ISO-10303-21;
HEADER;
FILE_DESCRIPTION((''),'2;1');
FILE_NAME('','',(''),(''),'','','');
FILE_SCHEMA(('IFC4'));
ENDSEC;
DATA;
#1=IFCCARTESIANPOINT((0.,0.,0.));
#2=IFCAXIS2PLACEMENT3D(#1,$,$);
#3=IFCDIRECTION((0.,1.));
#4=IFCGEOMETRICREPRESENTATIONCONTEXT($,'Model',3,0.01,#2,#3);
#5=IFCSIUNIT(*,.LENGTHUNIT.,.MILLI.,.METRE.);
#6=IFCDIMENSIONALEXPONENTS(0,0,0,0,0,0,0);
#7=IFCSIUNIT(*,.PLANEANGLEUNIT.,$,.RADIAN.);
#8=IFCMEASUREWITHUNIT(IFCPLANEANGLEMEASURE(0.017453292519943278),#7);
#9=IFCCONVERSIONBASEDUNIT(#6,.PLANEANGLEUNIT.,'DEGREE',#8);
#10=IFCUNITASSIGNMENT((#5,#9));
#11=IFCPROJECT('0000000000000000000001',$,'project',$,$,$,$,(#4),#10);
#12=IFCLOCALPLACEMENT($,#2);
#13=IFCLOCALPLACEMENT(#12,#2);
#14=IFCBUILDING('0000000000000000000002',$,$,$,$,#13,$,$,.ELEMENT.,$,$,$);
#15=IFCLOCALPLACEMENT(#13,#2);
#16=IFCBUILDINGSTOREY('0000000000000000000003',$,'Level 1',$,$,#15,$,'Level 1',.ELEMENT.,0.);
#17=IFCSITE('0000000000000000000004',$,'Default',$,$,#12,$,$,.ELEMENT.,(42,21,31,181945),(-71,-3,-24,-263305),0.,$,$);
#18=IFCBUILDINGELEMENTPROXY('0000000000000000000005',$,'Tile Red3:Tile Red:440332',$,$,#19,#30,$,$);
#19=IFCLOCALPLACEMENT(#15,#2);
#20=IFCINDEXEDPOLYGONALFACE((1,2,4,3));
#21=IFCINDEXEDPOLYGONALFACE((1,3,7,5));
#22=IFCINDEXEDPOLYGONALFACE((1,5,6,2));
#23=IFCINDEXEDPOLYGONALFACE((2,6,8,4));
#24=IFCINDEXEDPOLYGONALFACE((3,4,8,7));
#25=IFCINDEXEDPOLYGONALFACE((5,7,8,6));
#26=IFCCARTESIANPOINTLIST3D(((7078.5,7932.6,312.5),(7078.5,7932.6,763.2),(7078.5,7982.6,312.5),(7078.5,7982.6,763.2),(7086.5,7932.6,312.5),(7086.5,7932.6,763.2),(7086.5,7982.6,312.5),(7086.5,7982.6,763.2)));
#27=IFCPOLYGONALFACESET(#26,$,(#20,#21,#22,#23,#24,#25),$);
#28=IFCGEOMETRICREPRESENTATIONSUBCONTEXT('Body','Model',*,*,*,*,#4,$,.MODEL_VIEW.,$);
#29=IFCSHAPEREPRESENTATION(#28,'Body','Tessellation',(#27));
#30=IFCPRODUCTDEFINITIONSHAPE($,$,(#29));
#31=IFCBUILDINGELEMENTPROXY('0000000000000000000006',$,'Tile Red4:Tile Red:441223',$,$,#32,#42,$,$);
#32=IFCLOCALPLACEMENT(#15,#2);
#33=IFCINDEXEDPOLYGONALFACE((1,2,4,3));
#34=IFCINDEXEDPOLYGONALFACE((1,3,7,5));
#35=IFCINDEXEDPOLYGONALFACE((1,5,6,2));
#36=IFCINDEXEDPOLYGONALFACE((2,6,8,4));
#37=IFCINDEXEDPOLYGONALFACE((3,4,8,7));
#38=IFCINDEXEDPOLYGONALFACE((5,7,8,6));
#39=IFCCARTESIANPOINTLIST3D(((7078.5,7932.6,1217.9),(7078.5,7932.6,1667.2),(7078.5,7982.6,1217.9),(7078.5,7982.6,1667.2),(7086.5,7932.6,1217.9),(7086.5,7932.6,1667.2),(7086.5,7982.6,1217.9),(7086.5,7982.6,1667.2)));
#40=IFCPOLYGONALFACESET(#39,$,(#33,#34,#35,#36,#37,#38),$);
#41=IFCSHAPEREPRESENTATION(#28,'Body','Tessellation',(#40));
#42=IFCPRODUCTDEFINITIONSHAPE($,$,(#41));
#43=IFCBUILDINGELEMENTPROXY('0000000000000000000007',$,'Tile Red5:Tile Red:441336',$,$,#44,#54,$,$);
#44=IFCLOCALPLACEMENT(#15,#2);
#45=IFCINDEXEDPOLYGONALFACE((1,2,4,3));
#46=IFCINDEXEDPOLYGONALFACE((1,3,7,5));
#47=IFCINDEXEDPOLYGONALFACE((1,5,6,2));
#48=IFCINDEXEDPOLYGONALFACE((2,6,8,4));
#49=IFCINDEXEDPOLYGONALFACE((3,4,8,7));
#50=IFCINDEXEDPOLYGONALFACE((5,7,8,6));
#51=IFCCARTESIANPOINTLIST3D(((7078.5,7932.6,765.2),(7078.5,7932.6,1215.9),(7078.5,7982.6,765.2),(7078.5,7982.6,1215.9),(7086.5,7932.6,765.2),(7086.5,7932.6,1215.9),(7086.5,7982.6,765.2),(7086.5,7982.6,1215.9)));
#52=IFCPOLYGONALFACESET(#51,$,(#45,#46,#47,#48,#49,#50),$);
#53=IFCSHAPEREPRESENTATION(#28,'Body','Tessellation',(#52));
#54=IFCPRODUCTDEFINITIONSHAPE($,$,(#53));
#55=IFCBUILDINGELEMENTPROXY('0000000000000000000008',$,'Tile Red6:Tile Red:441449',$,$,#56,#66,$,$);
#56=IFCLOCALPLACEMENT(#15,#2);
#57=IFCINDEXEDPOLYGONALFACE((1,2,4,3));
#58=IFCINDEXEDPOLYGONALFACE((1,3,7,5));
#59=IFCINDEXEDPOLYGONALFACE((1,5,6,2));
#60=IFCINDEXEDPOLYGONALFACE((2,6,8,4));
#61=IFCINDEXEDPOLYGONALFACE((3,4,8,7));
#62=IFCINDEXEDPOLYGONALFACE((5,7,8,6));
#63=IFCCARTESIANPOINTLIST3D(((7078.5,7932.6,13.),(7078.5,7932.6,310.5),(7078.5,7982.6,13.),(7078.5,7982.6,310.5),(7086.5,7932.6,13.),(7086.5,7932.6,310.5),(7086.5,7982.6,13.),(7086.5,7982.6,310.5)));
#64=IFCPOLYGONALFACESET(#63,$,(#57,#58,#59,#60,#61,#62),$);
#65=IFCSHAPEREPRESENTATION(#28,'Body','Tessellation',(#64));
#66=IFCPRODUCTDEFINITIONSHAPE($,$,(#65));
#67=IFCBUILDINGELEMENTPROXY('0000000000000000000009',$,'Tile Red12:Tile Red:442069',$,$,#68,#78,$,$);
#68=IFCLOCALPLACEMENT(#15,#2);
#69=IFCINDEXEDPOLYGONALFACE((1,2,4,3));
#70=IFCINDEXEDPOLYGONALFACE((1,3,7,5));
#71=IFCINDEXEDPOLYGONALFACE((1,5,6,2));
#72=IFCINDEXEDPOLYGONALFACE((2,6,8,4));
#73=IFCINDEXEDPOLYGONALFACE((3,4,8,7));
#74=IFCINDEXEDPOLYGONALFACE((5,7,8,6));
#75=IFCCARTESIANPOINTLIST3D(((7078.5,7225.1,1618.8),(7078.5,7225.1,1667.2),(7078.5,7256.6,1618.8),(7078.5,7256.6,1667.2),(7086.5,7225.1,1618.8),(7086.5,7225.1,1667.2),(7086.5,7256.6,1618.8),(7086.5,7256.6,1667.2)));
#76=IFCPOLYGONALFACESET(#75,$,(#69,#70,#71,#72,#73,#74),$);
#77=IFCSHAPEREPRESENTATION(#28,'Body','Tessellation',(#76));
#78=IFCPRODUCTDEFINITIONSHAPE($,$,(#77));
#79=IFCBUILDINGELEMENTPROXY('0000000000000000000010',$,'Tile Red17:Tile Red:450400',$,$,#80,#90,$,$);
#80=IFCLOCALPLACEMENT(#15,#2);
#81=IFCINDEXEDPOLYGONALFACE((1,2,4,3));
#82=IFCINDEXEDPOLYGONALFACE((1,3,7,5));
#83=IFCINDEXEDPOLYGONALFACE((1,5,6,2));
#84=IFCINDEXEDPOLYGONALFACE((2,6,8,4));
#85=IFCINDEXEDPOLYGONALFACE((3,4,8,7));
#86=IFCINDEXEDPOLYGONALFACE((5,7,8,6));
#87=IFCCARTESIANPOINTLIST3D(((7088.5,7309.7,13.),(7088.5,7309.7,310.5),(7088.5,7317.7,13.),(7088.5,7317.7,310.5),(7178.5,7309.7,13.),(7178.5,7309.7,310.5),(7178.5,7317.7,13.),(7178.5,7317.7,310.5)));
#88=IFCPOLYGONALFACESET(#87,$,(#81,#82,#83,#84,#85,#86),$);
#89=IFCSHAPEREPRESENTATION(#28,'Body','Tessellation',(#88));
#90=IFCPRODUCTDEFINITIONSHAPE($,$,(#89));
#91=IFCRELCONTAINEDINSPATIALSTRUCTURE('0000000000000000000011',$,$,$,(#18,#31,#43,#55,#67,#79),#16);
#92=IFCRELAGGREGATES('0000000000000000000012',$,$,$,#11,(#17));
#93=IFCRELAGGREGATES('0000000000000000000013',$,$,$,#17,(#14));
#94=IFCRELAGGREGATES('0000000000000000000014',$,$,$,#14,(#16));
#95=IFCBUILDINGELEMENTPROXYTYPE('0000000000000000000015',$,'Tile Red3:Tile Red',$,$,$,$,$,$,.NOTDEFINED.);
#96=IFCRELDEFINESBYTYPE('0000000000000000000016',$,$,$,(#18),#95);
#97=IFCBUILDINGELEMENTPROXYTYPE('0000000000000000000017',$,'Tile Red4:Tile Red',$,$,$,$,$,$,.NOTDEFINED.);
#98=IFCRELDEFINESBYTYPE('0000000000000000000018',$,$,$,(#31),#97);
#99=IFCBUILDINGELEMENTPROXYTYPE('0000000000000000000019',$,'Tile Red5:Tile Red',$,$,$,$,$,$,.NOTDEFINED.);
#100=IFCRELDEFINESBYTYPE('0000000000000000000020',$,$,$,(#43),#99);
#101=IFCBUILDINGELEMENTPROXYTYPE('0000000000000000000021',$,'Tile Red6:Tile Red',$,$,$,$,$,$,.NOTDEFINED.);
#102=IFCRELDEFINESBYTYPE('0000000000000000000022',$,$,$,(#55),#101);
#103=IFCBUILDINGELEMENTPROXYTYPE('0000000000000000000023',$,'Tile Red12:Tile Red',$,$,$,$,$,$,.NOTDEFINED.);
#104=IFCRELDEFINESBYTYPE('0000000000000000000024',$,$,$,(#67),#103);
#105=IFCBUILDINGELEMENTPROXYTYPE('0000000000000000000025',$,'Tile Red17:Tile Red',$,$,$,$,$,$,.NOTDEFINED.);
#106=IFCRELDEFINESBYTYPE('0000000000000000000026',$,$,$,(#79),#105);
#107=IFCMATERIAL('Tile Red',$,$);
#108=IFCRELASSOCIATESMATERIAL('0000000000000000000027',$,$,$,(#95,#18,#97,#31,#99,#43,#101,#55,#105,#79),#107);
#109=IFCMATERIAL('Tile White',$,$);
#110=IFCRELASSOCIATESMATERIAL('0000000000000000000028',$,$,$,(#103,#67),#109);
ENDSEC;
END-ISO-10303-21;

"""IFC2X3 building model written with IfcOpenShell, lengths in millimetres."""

from ifc_helpers import new_model, entity, si_unit, converted_unit, direction, frame, frame_2d, origin, origin_2d_with_axis, place, context, subcontext, project, spatial, rectangle, extrude, source, transform, mapped, material, type_object, type_shapes, element, save


model = new_model("IFC2X3")

# Units and contexts
model_context = context("Model", 3, precision=0.01, world=origin(), true_north=direction((0.0, 1.0)))
body_context = subcontext(model_context, "Body", "Model", "MODEL_VIEW")
ifc_project = project(units=[si_unit("LENGTHUNIT", "METRE", prefix="MILLI"), converted_unit("PLANEANGLEUNIT", "DEGREE", entity("IfcPlaneAngleMeasure", 0.017453292519943278), si_unit("PLANEANGLEUNIT", "RADIAN"), dimensions=[0, 0, 0, 0, 0, 0, 0])], contexts=[model_context])

# Site, building, storey
site_placement = place(None, origin())
site = spatial("IfcSite", under=ifc_project, at=site_placement, Name="Default", CompositionType="ELEMENT", RefLatitude=(42, 21, 31, 181945), RefLongitude=(-71, -3, -24, -263305), RefElevation=0.0)
building_placement = place(site_placement, origin())
building = spatial("IfcBuilding", under=site, at=building_placement, CompositionType="ELEMENT")
storey_placement = place(building_placement, origin())
storey = spatial("IfcBuildingStorey", under=building, at=storey_placement, Name="Level 1", LongName="Level 1", CompositionType="ELEMENT", Elevation=0.0)

# Building element proxies
ifc_material_1 = material(Name="Tile Red")
building_element_proxy_type_1 = type_object("IfcBuildingElementProxyType", Name="Tile Red3:Tile Red", PredefinedType="NOTDEFINED", material=ifc_material_1)
shared_shape_1 = source(origin(), body_context, "Body", "SweptSolid", [
    extrude(rectangle(XDim=8.0, YDim=50.0, at=origin_2d_with_axis()), frame((7082.5, 7957.6, 312.5)), (0.0, 0.0, 1.0), 450.7),
])
type_shapes(building_element_proxy_type_1, [shared_shape_1])
proxy_1_placement = place(storey_placement, origin())
element("IfcBuildingElementProxy", 1, at=proxy_1_placement, inside=storey, type_object=building_element_proxy_type_1, material=ifc_material_1, Name="Tile Red3:Tile Red:440332", context=body_context, shape_type="MappedRepresentation", body=[
    mapped(shared_shape_1, transform((0.0, 0.0, 0.0), scale=1.0)),
])
building_element_proxy_type_2 = type_object("IfcBuildingElementProxyType", Name="Tile Red4:Tile Red", PredefinedType="NOTDEFINED", material=ifc_material_1)
shared_shape_2 = source(origin(), body_context, "Body", "SweptSolid", [
    extrude(rectangle(XDim=8.0, YDim=50.0, at=origin_2d_with_axis()), frame((7082.5, 7957.6, 1217.9)), (0.0, 0.0, 1.0), 449.3),
])
type_shapes(building_element_proxy_type_2, [shared_shape_2])
proxy_2_placement = place(storey_placement, origin())
element("IfcBuildingElementProxy", 2, at=proxy_2_placement, inside=storey, type_object=building_element_proxy_type_2, material=ifc_material_1, Name="Tile Red4:Tile Red:441223", context=body_context, shape_type="MappedRepresentation", body=[
    mapped(shared_shape_2, transform((0.0, 0.0, 0.0), scale=1.0)),
])
building_element_proxy_type_3 = type_object("IfcBuildingElementProxyType", Name="Tile Red5:Tile Red", PredefinedType="NOTDEFINED", material=ifc_material_1)
shared_shape_3 = source(origin(), body_context, "Body", "SweptSolid", [
    extrude(rectangle(XDim=8.0, YDim=50.0, at=origin_2d_with_axis()), frame((7082.5, 7957.6, 765.2)), (0.0, 0.0, 1.0), 450.7),
])
type_shapes(building_element_proxy_type_3, [shared_shape_3])
proxy_3_placement = place(storey_placement, origin())
element("IfcBuildingElementProxy", 3, at=proxy_3_placement, inside=storey, type_object=building_element_proxy_type_3, material=ifc_material_1, Name="Tile Red5:Tile Red:441336", context=body_context, shape_type="MappedRepresentation", body=[
    mapped(shared_shape_3, transform((0.0, 0.0, 0.0), scale=1.0)),
])
building_element_proxy_type_4 = type_object("IfcBuildingElementProxyType", Name="Tile Red6:Tile Red", PredefinedType="NOTDEFINED", material=ifc_material_1)
shared_shape_4 = source(origin(), body_context, "Body", "SweptSolid", [
    extrude(rectangle(XDim=8.0, YDim=50.0, at=origin_2d_with_axis()), frame((7082.5, 7957.6, 13.0)), (0.0, 0.0, 1.0), 297.5),
])
type_shapes(building_element_proxy_type_4, [shared_shape_4])
proxy_4_placement = place(storey_placement, origin())
element("IfcBuildingElementProxy", 4, at=proxy_4_placement, inside=storey, type_object=building_element_proxy_type_4, material=ifc_material_1, Name="Tile Red6:Tile Red:441449", context=body_context, shape_type="MappedRepresentation", body=[
    mapped(shared_shape_4, transform((0.0, 0.0, 0.0), scale=1.0)),
])
ifc_material_2 = material(Name="Tile White")
building_element_proxy_type_5 = type_object("IfcBuildingElementProxyType", Name="Tile Red12:Tile Red", PredefinedType="NOTDEFINED", material=ifc_material_2)
shared_shape_5 = source(origin(), body_context, "Body", "SweptSolid", [
    extrude(rectangle(XDim=8.0, YDim=31.5, at=frame_2d((0.0, 0.0), x_axis=(1.0, 0.0))), frame((7082.5, 7240.9, 1618.8)), (0.0, 0.0, 1.0), 48.4),
])
type_shapes(building_element_proxy_type_5, [shared_shape_5])
proxy_5_placement = place(storey_placement, origin())
element("IfcBuildingElementProxy", 5, at=proxy_5_placement, inside=storey, type_object=building_element_proxy_type_5, material=ifc_material_2, Name="Tile Red12:Tile Red:442069", context=body_context, shape_type="MappedRepresentation", body=[
    mapped(shared_shape_5, transform((0.0, 0.0, 0.0), scale=1.0)),
])
building_element_proxy_type_6 = type_object("IfcBuildingElementProxyType", Name="Tile Red17:Tile Red", PredefinedType="NOTDEFINED", material=ifc_material_1)
shared_shape_6 = source(origin(), body_context, "Body", "SweptSolid", [
    extrude(rectangle(XDim=8.0, YDim=90.0, at=frame_2d((0.0, 0.0), x_axis=(1.0, 0.0))), frame((7133.5, 7313.7, 0.0), z_axis=(0.0, 0.0, 1.0), x_axis=(0.0, -1.0, 0.0)), (0.0, 0.0, 1.0), 297.5),
])
type_shapes(building_element_proxy_type_6, [shared_shape_6])
proxy_6_placement = place(storey_placement, frame((0.0, 0.0, 13.0)))
element("IfcBuildingElementProxy", 6, at=proxy_6_placement, inside=storey, type_object=building_element_proxy_type_6, material=ifc_material_1, Name="Tile Red17:Tile Red:450400", context=body_context, shape_type="MappedRepresentation", body=[
    mapped(shared_shape_6, transform((0.0, 0.0, 0.0), scale=1.0)),
])

save(model, "model.ifc")
